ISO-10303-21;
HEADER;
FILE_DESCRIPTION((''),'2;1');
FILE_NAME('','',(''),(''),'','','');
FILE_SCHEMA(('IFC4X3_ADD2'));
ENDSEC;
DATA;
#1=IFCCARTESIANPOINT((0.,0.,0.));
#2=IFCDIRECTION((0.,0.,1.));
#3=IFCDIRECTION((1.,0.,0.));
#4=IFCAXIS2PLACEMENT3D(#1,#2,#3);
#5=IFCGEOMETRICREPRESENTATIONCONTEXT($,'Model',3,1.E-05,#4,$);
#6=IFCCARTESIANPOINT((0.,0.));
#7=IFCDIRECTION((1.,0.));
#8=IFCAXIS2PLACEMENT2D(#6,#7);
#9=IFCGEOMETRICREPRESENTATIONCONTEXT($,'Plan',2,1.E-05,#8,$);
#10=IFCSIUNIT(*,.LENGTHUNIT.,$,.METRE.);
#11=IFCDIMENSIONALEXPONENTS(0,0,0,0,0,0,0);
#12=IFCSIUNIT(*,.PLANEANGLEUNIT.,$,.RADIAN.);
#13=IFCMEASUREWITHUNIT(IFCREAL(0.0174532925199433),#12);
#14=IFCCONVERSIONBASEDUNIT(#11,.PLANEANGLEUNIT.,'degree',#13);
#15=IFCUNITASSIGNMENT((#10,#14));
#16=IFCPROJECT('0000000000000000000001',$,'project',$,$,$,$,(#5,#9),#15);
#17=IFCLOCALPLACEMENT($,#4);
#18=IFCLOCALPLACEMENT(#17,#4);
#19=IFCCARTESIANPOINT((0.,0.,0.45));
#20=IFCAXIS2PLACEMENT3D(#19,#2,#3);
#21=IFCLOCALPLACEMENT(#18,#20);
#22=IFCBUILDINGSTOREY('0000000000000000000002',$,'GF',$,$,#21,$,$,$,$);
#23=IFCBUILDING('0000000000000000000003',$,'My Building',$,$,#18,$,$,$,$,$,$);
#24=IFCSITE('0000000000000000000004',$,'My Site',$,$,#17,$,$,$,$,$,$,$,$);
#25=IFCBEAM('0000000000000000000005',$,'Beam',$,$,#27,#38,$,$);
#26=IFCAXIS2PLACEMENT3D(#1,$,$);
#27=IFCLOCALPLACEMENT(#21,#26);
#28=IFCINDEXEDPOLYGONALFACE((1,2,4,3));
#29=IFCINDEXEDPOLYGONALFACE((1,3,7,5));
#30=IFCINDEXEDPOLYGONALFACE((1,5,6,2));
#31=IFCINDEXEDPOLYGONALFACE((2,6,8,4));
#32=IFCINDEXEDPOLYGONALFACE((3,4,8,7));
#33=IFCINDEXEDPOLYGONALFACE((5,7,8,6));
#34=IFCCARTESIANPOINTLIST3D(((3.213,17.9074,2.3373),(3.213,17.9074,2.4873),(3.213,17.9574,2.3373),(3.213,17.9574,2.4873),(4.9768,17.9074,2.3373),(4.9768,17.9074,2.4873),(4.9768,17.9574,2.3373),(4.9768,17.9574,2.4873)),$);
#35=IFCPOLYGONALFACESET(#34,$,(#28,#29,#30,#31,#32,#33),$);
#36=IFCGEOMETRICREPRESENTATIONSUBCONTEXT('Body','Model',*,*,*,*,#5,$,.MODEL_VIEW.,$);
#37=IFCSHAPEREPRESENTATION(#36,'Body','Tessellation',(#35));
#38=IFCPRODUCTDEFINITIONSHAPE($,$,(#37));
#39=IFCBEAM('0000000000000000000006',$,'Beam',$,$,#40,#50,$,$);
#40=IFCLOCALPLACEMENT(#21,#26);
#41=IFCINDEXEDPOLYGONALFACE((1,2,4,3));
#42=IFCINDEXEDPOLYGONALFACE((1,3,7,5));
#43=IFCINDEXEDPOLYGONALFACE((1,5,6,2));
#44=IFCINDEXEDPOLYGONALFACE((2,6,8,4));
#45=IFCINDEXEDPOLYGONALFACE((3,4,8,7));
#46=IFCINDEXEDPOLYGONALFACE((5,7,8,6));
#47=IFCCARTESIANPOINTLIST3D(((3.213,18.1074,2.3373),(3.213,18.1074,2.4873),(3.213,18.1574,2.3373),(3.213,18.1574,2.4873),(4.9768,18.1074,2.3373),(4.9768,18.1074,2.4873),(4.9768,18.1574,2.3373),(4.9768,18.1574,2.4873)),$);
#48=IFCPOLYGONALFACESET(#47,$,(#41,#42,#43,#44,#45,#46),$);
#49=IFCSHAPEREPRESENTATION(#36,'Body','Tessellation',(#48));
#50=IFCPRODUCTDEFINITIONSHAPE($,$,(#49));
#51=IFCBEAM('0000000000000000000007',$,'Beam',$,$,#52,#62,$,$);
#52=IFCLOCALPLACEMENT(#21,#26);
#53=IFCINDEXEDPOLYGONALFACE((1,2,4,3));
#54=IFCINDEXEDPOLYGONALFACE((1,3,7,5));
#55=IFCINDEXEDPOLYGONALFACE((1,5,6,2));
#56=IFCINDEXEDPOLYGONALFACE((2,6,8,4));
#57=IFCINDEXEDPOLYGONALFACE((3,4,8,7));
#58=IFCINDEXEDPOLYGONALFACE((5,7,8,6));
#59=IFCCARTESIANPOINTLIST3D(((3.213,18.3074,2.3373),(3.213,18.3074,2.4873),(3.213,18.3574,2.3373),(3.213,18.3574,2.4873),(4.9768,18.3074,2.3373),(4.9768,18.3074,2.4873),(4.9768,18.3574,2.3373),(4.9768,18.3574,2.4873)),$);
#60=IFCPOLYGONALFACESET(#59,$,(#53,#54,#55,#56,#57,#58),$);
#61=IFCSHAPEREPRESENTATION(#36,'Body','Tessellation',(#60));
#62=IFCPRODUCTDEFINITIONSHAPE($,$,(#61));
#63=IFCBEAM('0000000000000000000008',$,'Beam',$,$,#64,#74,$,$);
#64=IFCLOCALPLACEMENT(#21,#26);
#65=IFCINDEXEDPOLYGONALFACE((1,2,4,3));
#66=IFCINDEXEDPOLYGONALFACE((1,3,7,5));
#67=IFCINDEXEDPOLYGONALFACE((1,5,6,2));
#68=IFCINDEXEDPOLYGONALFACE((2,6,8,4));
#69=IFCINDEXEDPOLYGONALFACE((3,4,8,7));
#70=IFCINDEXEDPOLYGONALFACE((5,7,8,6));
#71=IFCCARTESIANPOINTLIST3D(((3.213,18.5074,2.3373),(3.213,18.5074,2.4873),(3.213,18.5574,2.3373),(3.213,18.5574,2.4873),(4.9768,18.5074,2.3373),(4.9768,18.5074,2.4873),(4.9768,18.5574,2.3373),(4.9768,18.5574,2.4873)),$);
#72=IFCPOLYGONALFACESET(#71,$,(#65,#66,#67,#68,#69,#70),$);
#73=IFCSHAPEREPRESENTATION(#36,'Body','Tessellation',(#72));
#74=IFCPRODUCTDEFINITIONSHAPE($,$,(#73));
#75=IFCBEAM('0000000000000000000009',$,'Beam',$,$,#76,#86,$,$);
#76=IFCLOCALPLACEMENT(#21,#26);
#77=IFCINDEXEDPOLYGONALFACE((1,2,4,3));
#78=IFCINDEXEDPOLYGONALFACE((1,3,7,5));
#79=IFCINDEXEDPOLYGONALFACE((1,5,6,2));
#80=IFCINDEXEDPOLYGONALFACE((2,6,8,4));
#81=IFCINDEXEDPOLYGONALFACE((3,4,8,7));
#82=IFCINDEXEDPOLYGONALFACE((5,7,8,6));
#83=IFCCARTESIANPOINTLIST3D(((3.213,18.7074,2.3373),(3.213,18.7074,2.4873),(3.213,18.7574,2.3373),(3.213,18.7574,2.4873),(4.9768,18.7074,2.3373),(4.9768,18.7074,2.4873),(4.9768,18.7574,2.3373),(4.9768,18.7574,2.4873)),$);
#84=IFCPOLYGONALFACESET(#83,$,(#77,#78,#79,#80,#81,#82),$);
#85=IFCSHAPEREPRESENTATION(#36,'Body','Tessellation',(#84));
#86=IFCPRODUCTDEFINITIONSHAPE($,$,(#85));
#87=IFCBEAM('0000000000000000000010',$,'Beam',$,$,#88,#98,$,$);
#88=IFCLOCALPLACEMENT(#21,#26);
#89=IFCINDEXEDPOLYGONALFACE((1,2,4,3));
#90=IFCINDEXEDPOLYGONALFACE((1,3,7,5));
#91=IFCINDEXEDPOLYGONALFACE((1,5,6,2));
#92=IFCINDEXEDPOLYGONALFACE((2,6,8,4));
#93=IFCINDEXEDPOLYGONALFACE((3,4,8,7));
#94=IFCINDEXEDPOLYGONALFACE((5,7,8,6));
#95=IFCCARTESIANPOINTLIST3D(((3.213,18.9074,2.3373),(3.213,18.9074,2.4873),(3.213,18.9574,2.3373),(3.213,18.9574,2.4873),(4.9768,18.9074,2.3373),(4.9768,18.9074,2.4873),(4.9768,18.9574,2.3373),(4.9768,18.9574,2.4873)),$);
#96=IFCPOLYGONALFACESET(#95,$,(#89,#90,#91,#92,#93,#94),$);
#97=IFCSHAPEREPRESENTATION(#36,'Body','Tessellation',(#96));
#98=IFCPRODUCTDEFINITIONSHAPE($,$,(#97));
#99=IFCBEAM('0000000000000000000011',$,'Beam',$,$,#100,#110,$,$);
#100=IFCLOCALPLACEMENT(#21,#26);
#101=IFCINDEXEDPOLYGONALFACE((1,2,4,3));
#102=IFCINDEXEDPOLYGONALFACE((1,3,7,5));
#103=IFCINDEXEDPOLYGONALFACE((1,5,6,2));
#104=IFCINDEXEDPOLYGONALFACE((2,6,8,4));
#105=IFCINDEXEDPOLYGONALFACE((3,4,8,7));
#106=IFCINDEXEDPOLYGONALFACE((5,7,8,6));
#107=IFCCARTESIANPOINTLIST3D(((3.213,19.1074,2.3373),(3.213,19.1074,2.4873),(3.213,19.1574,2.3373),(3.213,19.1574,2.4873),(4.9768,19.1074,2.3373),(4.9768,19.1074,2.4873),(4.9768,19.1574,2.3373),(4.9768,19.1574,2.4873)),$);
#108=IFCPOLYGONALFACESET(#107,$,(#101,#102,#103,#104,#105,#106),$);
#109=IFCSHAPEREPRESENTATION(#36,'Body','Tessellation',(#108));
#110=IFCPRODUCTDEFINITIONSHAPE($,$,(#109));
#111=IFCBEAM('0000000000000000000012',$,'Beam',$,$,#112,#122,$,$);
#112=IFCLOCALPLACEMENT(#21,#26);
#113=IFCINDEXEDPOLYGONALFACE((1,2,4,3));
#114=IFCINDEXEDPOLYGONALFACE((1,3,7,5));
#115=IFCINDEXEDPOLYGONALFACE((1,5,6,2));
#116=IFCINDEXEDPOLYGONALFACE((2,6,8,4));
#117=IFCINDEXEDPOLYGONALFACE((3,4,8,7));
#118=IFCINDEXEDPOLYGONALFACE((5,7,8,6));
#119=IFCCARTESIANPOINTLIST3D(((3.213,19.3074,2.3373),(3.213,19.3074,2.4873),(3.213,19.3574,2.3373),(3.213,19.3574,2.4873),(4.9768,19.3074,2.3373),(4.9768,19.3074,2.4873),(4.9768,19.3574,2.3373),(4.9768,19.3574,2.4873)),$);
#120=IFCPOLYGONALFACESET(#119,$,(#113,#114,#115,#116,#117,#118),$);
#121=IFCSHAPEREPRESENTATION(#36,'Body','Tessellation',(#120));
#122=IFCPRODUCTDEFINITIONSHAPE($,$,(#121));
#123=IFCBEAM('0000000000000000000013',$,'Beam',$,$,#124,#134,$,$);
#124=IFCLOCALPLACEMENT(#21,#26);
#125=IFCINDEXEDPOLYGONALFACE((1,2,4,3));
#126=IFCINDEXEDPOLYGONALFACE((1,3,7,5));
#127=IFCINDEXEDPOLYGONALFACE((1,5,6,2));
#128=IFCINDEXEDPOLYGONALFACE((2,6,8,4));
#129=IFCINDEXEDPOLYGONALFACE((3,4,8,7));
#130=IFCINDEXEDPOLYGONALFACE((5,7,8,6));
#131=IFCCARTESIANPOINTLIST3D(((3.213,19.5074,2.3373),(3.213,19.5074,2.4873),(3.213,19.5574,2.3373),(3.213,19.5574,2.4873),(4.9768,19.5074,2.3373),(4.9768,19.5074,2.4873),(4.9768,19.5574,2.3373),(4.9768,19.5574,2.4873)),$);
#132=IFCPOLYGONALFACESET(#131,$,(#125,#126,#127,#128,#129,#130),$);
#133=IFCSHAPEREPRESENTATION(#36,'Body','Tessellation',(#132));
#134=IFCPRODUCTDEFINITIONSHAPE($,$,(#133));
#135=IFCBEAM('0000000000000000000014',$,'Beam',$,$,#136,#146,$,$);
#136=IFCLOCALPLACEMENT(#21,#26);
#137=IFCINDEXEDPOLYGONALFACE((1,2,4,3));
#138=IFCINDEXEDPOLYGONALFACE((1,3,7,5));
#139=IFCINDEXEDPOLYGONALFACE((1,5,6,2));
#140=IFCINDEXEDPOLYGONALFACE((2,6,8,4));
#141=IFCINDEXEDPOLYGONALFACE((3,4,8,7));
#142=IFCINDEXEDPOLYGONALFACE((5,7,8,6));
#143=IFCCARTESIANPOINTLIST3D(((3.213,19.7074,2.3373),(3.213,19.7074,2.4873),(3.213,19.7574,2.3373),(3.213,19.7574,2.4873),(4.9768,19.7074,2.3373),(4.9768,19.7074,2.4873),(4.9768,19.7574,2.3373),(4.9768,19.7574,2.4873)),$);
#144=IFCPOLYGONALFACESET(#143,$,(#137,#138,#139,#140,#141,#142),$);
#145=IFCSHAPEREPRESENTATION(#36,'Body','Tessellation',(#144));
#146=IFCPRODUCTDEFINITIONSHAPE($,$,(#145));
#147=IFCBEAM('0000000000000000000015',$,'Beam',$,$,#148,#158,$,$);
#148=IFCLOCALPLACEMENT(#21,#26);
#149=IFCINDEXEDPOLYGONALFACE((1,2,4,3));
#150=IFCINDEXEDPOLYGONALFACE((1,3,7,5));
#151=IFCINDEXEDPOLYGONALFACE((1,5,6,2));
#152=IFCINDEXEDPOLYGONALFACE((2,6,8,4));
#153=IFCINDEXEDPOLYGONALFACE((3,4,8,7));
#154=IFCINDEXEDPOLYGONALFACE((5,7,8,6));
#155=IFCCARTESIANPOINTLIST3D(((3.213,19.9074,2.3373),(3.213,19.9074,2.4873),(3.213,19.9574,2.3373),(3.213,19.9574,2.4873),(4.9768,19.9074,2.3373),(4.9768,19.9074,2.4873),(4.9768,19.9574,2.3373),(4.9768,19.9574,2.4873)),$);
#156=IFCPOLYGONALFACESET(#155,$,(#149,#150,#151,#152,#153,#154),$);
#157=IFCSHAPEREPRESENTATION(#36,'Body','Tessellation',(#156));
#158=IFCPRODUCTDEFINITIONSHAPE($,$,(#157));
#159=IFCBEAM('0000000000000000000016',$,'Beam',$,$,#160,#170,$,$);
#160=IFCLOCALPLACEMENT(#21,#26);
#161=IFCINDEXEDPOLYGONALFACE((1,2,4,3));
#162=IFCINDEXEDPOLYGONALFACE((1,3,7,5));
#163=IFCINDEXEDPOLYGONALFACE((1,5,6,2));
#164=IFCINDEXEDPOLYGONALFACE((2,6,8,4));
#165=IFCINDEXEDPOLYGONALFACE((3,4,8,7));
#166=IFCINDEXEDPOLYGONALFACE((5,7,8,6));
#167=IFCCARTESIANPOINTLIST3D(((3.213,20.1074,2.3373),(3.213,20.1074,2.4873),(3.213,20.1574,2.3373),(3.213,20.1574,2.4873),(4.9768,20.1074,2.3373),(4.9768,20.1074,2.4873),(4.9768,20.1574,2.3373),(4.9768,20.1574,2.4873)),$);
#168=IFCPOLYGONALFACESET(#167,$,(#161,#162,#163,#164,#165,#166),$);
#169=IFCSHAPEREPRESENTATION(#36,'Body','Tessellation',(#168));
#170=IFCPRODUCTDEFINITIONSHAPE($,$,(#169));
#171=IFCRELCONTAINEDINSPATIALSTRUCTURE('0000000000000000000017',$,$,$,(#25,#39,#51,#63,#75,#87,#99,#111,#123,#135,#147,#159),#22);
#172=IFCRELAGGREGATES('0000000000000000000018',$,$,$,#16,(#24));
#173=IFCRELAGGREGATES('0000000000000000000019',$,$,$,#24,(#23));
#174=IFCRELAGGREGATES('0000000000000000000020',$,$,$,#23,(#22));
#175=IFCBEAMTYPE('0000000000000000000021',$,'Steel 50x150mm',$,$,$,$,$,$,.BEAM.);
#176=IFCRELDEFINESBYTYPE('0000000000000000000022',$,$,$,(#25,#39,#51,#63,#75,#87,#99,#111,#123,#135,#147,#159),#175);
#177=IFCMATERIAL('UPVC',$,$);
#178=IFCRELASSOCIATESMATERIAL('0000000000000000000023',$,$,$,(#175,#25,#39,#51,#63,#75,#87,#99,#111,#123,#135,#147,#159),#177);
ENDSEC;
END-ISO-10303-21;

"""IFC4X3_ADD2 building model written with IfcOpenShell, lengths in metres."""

from ifc_helpers import new_model, entity, si_unit, converted_unit, frame, origin_with_axes, origin_2d_with_axis, place, context, subcontext, project, spatial, rectangle, extrude, material, material_profile, profile_set, profile_usage, type_object, element, save


model = new_model("IFC4X3_ADD2")

# Units and contexts
model_context = context("Model", 3, precision=1e-05, world=origin_with_axes())
plan_context = context("Plan", 2, precision=1e-05, world=origin_2d_with_axis())
body_context = subcontext(model_context, "Body", "Model", "MODEL_VIEW")
ifc_project = project(units=[si_unit("LENGTHUNIT", "METRE"), converted_unit("PLANEANGLEUNIT", "degree", entity("IfcReal", 0.0174532925199433), si_unit("PLANEANGLEUNIT", "RADIAN"), dimensions=[0, 0, 0, 0, 0, 0, 0])], contexts=[model_context, plan_context])

# Site, building, storey
site_placement = place(None, origin_with_axes())
site = spatial("IfcSite", under=ifc_project, at=site_placement, Name="My Site")
building_placement = place(site_placement, origin_with_axes())
building = spatial("IfcBuilding", under=site, at=building_placement, Name="My Building")
storey_placement = place(building_placement, frame((0.0, 0.0, 0.45), z_axis=(0.0, 0.0, 1.0), x_axis=(1.0, 0.0, 0.0)))
storey = spatial("IfcBuildingStorey", under=building, at=storey_placement, Name="GF")

# Beams
ifc_material_1 = material(Name="UPVC")
ifc_material_profile = material_profile(ifc_material_1, rectangle(XDim=0.05, YDim=0.15))
ifc_profile_set = profile_set([ifc_material_profile])
beam_type = type_object("IfcBeamType", Name="Steel 50x150mm", PredefinedType="BEAM", material=ifc_profile_set)
ifc_profile_usage_1 = profile_usage(ifc_profile_set)
beam_1_placement = place(storey_placement, frame((3.213, 17.9324, 2.4123), z_axis=(1.0, 0.0, 0.0), x_axis=(0.0, 1.0, 0.0)))
element("IfcBeam", 1, at=beam_1_placement, inside=storey, type_object=beam_type, material=ifc_profile_usage_1, Name="Beam", context=body_context, shape_type="SweptSolid", body=[
    extrude(rectangle(XDim=0.05, YDim=0.15), origin_with_axes(), (0.0, 0.0, 1.0), 1.7638),
])
ifc_profile_usage_2 = profile_usage(ifc_profile_set)
beam_2_placement = place(storey_placement, frame((3.213, 18.1324, 2.4123), z_axis=(1.0, 0.0, 0.0), x_axis=(0.0, 1.0, 0.0)))
element("IfcBeam", 2, at=beam_2_placement, inside=storey, type_object=beam_type, material=ifc_profile_usage_2, Name="Beam", context=body_context, shape_type="SweptSolid", body=[
    extrude(rectangle(XDim=0.05, YDim=0.15), origin_with_axes(), (0.0, 0.0, 1.0), 1.7638),
])
ifc_profile_usage_3 = profile_usage(ifc_profile_set)
beam_3_placement = place(storey_placement, frame((3.213, 18.3324, 2.4123), z_axis=(1.0, 0.0, 0.0), x_axis=(0.0, 1.0, 0.0)))
element("IfcBeam", 3, at=beam_3_placement, inside=storey, type_object=beam_type, material=ifc_profile_usage_3, Name="Beam", context=body_context, shape_type="SweptSolid", body=[
    extrude(rectangle(XDim=0.05, YDim=0.15), origin_with_axes(), (0.0, 0.0, 1.0), 1.7638),
])
ifc_profile_usage_4 = profile_usage(ifc_profile_set)
beam_4_placement = place(storey_placement, frame((3.213, 18.5324, 2.4123), z_axis=(1.0, 0.0, 0.0), x_axis=(0.0, 1.0, 0.0)))
element("IfcBeam", 4, at=beam_4_placement, inside=storey, type_object=beam_type, material=ifc_profile_usage_4, Name="Beam", context=body_context, shape_type="SweptSolid", body=[
    extrude(rectangle(XDim=0.05, YDim=0.15), origin_with_axes(), (0.0, 0.0, 1.0), 1.7638),
])
ifc_profile_usage_5 = profile_usage(ifc_profile_set)
beam_5_placement = place(storey_placement, frame((3.213, 18.7324, 2.4123), z_axis=(1.0, 0.0, 0.0), x_axis=(0.0, 1.0, 0.0)))
element("IfcBeam", 5, at=beam_5_placement, inside=storey, type_object=beam_type, material=ifc_profile_usage_5, Name="Beam", context=body_context, shape_type="SweptSolid", body=[
    extrude(rectangle(XDim=0.05, YDim=0.15), origin_with_axes(), (0.0, 0.0, 1.0), 1.7638),
])
ifc_profile_usage_6 = profile_usage(ifc_profile_set)
beam_6_placement = place(storey_placement, frame((3.213, 18.9324, 2.4123), z_axis=(1.0, 0.0, 0.0), x_axis=(0.0, 1.0, 0.0)))
element("IfcBeam", 6, at=beam_6_placement, inside=storey, type_object=beam_type, material=ifc_profile_usage_6, Name="Beam", context=body_context, shape_type="SweptSolid", body=[
    extrude(rectangle(XDim=0.05, YDim=0.15), origin_with_axes(), (0.0, 0.0, 1.0), 1.7638),
])
ifc_profile_usage_7 = profile_usage(ifc_profile_set)
beam_7_placement = place(storey_placement, frame((3.213, 19.1324, 2.4123), z_axis=(1.0, 0.0, 0.0), x_axis=(0.0, 1.0, 0.0)))
element("IfcBeam", 7, at=beam_7_placement, inside=storey, type_object=beam_type, material=ifc_profile_usage_7, Name="Beam", context=body_context, shape_type="SweptSolid", body=[
    extrude(rectangle(XDim=0.05, YDim=0.15), origin_with_axes(), (0.0, 0.0, 1.0), 1.7638),
])
ifc_profile_usage_8 = profile_usage(ifc_profile_set)
beam_8_placement = place(storey_placement, frame((3.213, 19.3324, 2.4123), z_axis=(1.0, 0.0, 0.0), x_axis=(0.0, 1.0, 0.0)))
element("IfcBeam", 8, at=beam_8_placement, inside=storey, type_object=beam_type, material=ifc_profile_usage_8, Name="Beam", context=body_context, shape_type="SweptSolid", body=[
    extrude(rectangle(XDim=0.05, YDim=0.15), origin_with_axes(), (0.0, 0.0, 1.0), 1.7638),
])
ifc_profile_usage_9 = profile_usage(ifc_profile_set)
beam_9_placement = place(storey_placement, frame((3.213, 19.5324, 2.4123), z_axis=(1.0, 0.0, 0.0), x_axis=(0.0, 1.0, 0.0)))
element("IfcBeam", 9, at=beam_9_placement, inside=storey, type_object=beam_type, material=ifc_profile_usage_9, Name="Beam", context=body_context, shape_type="SweptSolid", body=[
    extrude(rectangle(XDim=0.05, YDim=0.15), origin_with_axes(), (0.0, 0.0, 1.0), 1.7638),
])
ifc_profile_usage_10 = profile_usage(ifc_profile_set)
beam_10_placement = place(storey_placement, frame((3.213, 19.7324, 2.4123), z_axis=(1.0, 0.0, 0.0), x_axis=(0.0, 1.0, 0.0)))
element("IfcBeam", 10, at=beam_10_placement, inside=storey, type_object=beam_type, material=ifc_profile_usage_10, Name="Beam", context=body_context, shape_type="SweptSolid", body=[
    extrude(rectangle(XDim=0.05, YDim=0.15), origin_with_axes(), (0.0, 0.0, 1.0), 1.7638),
])
ifc_profile_usage_11 = profile_usage(ifc_profile_set)
beam_11_placement = place(storey_placement, frame((3.213, 19.9324, 2.4123), z_axis=(1.0, 0.0, 0.0), x_axis=(0.0, 1.0, 0.0)))
element("IfcBeam", 11, at=beam_11_placement, inside=storey, type_object=beam_type, material=ifc_profile_usage_11, Name="Beam", context=body_context, shape_type="SweptSolid", body=[
    extrude(rectangle(XDim=0.05, YDim=0.15), origin_with_axes(), (0.0, 0.0, 1.0), 1.7638),
])
ifc_profile_usage_12 = profile_usage(ifc_profile_set)
beam_12_placement = place(storey_placement, frame((3.213, 20.1324, 2.4123), z_axis=(1.0, 0.0, 0.0), x_axis=(0.0, 1.0, 0.0)))
element("IfcBeam", 12, at=beam_12_placement, inside=storey, type_object=beam_type, material=ifc_profile_usage_12, Name="Beam", context=body_context, shape_type="SweptSolid", body=[
    extrude(rectangle(XDim=0.05, YDim=0.15), origin_with_axes(), (0.0, 0.0, 1.0), 1.7638),
])

save(model, "model.ifc")
